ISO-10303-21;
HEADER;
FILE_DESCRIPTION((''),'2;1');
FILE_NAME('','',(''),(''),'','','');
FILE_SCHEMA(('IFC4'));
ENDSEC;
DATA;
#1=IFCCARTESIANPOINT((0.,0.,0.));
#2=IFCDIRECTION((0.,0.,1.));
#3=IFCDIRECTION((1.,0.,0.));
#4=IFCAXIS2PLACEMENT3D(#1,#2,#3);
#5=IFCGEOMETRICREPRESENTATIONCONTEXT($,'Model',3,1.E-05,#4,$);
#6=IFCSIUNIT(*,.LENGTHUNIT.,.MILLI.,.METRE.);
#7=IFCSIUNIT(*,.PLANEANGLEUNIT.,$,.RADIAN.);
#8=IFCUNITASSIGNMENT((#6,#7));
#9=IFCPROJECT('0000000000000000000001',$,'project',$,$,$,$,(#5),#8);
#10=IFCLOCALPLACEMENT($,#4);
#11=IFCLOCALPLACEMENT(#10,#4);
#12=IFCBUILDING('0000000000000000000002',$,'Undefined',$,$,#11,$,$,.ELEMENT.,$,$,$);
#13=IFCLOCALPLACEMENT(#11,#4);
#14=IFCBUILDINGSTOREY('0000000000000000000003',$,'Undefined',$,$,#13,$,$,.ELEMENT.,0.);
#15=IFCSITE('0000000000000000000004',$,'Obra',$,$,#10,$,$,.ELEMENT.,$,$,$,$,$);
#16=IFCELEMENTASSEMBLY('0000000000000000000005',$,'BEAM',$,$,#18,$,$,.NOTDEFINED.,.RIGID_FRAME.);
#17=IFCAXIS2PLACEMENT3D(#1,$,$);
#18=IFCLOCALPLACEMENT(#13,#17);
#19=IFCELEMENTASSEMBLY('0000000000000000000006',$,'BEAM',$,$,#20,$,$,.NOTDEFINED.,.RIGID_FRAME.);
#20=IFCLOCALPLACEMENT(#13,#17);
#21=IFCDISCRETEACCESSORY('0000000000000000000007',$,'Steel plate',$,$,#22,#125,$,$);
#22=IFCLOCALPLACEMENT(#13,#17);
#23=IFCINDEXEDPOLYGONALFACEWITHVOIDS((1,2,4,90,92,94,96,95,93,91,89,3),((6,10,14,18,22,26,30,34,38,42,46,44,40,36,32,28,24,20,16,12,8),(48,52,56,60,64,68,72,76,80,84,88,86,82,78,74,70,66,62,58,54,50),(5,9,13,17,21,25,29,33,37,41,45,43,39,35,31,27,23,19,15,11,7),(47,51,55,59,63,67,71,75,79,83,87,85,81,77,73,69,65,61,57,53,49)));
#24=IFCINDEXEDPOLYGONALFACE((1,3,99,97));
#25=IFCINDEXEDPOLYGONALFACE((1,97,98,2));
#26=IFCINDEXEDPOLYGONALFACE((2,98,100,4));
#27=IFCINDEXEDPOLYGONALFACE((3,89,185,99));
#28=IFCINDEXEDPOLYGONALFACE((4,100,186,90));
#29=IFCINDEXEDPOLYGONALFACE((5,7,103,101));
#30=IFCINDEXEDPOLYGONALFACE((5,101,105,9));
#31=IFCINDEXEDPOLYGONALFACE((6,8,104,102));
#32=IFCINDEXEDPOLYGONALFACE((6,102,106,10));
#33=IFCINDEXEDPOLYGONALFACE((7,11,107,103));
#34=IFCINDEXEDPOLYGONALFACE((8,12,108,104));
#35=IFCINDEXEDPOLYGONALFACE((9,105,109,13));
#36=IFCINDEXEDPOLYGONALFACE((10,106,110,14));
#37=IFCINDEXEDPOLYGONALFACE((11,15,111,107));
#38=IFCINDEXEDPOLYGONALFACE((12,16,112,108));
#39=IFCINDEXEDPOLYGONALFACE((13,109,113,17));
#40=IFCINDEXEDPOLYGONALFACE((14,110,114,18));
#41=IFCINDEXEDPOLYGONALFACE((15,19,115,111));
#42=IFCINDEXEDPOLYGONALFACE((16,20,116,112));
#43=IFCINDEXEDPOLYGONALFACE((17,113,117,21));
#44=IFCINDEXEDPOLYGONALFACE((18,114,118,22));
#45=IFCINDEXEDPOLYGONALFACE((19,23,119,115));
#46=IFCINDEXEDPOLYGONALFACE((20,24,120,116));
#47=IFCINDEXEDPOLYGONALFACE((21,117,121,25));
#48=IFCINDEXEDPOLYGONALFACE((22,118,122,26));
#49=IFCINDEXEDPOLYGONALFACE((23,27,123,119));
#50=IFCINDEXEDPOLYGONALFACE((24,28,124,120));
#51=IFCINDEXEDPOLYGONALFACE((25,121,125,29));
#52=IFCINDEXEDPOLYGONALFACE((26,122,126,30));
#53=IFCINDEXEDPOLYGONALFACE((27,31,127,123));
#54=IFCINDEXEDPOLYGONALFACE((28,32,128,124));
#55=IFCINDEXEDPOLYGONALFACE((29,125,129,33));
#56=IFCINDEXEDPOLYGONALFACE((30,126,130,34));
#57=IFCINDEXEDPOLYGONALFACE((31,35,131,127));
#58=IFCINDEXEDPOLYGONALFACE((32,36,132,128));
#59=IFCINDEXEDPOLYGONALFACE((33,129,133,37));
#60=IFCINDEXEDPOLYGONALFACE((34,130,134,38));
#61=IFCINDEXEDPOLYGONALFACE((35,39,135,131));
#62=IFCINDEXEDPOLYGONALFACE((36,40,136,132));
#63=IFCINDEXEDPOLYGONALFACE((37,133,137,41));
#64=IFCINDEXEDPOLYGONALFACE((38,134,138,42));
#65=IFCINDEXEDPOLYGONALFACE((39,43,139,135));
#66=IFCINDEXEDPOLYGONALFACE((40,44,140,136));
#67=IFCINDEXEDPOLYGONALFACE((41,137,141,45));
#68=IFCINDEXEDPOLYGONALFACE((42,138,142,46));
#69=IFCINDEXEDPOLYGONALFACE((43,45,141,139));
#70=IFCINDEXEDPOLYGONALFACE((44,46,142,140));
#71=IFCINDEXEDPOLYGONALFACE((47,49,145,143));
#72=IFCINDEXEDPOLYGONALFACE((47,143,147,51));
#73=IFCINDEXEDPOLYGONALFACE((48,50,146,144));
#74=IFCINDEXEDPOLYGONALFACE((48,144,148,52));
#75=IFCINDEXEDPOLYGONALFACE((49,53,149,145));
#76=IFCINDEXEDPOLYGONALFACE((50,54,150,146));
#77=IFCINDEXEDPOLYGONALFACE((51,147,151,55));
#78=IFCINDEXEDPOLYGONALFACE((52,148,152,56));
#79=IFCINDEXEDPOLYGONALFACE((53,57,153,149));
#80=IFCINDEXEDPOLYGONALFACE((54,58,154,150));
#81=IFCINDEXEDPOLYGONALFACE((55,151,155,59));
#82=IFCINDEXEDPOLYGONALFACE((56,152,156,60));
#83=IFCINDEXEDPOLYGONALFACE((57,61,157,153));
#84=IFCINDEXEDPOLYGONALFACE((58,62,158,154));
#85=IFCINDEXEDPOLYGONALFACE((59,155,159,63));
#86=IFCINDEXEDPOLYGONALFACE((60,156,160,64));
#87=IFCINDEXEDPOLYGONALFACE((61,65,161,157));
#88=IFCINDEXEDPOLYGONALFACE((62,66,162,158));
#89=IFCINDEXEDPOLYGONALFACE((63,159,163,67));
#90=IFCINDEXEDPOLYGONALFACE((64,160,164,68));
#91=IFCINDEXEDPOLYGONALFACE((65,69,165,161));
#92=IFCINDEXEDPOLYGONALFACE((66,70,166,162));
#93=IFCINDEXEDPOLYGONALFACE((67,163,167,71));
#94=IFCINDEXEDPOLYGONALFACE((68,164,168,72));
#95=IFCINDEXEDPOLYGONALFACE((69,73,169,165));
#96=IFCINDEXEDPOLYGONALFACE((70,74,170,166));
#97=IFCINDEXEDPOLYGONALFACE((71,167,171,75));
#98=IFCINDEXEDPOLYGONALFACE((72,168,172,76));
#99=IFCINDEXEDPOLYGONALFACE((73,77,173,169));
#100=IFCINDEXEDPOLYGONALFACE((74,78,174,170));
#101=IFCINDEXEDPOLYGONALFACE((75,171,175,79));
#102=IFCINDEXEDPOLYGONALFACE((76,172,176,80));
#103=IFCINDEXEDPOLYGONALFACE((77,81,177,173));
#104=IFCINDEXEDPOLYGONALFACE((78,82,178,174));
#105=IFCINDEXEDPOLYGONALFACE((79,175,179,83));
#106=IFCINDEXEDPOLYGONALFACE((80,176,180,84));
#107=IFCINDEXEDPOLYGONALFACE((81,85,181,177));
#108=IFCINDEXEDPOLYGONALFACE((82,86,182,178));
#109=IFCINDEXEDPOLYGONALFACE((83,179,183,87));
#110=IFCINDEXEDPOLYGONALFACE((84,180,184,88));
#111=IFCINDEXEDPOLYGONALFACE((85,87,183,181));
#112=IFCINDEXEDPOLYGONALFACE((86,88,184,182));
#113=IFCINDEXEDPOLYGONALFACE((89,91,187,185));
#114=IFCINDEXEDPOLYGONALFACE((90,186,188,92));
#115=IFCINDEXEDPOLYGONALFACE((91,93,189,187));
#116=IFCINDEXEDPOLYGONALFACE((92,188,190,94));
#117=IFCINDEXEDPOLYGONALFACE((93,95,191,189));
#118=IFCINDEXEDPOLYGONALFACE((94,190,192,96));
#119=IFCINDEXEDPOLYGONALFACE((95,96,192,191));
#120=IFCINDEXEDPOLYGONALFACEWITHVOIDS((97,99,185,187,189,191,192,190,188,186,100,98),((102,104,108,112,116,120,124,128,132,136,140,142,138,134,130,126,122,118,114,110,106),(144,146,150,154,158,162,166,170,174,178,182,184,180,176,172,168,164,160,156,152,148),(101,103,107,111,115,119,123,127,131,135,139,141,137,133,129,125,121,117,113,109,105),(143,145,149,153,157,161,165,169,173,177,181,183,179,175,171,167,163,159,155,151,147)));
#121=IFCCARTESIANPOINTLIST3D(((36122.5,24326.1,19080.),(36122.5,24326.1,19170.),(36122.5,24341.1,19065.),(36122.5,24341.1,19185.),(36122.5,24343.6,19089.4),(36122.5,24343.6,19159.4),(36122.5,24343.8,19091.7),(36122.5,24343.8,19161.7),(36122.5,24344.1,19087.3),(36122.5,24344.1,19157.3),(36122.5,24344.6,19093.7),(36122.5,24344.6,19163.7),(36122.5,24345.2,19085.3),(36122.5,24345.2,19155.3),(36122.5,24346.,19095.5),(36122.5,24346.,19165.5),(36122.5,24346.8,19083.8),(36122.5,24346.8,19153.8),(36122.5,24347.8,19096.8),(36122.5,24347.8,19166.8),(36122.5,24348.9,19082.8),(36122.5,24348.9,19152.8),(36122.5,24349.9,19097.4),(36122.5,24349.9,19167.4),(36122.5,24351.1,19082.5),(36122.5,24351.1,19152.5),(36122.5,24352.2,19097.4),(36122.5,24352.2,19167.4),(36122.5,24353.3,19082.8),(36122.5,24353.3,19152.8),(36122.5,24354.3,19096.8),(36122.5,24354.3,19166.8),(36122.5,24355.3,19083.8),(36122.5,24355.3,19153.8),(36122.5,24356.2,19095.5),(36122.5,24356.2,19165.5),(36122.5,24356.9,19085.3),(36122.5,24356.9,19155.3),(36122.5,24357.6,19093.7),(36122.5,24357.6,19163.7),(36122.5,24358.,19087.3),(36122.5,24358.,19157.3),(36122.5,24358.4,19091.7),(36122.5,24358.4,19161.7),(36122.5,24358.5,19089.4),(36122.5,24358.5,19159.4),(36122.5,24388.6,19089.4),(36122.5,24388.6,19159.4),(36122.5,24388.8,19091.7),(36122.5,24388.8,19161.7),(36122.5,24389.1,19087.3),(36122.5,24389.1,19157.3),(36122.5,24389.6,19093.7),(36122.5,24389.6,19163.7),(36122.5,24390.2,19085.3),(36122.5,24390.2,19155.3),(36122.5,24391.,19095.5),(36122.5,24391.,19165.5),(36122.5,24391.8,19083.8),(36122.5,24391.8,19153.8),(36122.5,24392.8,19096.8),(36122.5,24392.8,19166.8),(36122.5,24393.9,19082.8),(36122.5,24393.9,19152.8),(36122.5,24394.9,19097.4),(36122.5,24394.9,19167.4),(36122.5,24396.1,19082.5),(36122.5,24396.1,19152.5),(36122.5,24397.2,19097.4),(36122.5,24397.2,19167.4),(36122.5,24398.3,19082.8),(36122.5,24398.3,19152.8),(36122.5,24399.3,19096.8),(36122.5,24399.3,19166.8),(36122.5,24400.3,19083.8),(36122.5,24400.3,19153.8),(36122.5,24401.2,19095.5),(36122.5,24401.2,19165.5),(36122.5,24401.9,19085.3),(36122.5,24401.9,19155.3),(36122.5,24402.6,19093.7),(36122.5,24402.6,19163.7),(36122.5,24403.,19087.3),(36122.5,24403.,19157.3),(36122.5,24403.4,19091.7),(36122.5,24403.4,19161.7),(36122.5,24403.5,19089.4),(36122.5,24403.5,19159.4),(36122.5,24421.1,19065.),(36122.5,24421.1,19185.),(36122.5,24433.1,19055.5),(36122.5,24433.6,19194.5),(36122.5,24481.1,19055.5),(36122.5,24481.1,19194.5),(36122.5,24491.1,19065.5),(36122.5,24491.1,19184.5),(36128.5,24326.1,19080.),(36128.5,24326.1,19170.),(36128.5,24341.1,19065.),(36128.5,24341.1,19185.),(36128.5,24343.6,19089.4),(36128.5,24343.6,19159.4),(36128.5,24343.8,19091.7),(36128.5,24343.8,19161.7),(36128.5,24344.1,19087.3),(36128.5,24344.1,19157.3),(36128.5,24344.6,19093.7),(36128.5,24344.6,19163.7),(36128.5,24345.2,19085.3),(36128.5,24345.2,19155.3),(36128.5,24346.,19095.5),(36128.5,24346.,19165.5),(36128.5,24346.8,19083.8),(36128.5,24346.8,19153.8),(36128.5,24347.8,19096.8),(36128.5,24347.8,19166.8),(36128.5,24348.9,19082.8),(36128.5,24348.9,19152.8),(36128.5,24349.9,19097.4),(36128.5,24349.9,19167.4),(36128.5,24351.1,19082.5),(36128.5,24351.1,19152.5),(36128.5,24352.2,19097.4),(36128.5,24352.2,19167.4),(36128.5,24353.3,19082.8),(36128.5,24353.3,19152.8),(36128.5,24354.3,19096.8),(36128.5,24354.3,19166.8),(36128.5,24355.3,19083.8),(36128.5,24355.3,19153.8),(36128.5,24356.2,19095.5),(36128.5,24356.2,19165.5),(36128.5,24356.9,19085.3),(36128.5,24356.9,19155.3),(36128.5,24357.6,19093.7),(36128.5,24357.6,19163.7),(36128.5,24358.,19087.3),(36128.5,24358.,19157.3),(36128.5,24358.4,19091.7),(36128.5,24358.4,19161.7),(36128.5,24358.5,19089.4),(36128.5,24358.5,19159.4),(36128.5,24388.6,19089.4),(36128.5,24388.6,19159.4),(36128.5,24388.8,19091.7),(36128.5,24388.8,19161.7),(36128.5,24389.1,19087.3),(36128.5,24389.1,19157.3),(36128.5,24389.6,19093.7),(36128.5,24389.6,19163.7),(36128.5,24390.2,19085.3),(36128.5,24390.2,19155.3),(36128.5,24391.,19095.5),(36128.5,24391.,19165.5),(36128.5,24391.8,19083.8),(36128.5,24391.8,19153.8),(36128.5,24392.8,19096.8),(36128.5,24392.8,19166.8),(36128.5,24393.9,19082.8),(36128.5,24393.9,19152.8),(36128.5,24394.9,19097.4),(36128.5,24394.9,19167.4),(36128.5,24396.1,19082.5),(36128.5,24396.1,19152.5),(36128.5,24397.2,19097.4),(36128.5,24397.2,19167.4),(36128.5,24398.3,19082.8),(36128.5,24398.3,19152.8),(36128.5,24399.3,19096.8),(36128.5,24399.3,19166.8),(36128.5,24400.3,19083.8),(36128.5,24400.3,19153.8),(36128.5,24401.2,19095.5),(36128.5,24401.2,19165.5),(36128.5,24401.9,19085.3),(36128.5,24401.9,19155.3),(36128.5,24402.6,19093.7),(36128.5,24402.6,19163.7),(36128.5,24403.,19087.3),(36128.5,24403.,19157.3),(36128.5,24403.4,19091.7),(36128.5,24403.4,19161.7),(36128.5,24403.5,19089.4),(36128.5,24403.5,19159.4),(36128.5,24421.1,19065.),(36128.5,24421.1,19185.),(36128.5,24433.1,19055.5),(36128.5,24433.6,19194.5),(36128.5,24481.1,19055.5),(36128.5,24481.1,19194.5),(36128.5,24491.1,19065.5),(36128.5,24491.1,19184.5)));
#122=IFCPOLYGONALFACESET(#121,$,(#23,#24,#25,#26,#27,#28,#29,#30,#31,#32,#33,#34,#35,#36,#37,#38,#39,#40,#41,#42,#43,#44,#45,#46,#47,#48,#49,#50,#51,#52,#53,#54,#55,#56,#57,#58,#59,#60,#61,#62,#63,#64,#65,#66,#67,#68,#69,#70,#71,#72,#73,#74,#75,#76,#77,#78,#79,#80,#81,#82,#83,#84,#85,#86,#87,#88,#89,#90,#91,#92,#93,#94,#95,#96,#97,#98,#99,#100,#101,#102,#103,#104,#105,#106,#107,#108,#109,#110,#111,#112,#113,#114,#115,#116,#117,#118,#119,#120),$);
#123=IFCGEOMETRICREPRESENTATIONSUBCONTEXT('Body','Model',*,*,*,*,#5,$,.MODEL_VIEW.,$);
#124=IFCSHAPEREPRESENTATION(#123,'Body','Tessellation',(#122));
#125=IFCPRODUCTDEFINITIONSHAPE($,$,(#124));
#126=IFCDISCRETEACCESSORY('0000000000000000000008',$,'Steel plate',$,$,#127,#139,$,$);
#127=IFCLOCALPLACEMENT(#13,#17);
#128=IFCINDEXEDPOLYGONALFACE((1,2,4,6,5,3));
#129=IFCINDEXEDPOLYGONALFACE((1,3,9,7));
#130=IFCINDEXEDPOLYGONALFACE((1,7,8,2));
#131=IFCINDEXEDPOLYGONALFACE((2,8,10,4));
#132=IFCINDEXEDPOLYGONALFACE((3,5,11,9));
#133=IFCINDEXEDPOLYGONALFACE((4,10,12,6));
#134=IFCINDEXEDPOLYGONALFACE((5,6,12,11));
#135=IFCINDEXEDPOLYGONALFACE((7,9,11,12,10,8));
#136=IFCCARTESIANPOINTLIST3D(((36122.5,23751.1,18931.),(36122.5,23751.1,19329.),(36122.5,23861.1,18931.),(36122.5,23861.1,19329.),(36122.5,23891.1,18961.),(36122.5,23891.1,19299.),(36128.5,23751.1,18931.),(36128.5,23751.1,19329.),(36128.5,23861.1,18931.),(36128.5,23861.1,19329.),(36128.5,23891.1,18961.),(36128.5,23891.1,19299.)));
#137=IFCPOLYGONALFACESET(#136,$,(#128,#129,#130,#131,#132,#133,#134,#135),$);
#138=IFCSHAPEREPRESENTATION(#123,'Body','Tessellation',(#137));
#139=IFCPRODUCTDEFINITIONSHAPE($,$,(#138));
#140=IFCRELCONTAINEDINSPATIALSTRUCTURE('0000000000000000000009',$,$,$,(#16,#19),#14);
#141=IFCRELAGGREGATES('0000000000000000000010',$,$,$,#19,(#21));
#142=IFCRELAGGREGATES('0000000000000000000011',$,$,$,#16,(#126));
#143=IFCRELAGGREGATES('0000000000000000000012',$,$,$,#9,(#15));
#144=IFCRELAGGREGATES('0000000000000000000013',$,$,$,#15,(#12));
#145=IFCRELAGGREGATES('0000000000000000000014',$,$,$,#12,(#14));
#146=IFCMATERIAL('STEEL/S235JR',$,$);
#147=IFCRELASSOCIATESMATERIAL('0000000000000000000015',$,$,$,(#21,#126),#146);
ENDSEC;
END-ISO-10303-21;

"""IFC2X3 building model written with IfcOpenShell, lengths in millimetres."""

from ifc_helpers import new_model, si_unit, frame, origin_with_axes, origin_2d_with_axis, place, context, subcontext, project, spatial, polyline, circle, outline, extrude, source, transform, mapped, material, element, aggregate, save


model = new_model("IFC2X3")

# Units and contexts
model_context = context("Model", 3, precision=1e-05, world=origin_with_axes())
body_context = subcontext(model_context, "Body", "Model", "MODEL_VIEW")
ifc_project = project(units=[si_unit("LENGTHUNIT", "METRE", prefix="MILLI"), si_unit("PLANEANGLEUNIT", "RADIAN")], contexts=[model_context])

# Site, building, storey
site_placement = place(None, origin_with_axes())
site = spatial("IfcSite", under=ifc_project, at=site_placement, Name="Obra", CompositionType="ELEMENT")
building_placement = place(site_placement, origin_with_axes())
building = spatial("IfcBuilding", under=site, at=building_placement, Name="Undefined", CompositionType="ELEMENT")
storey_placement = place(building_placement, origin_with_axes())
storey = spatial("IfcBuildingStorey", under=building, at=storey_placement, Name="Undefined", CompositionType="ELEMENT", Elevation=0.0)

# Shared definitions
ifc_material_1 = material(Name="STEEL/S235JR")

# Element assembly
assembly_1_placement = place(storey_placement, origin_with_axes())
assembly_1 = element("IfcElementAssembly", 1, at=assembly_1_placement, inside=storey, Name="BEAM", AssemblyPlace="NOTDEFINED", PredefinedType="RIGID_FRAME")

# Element assembly
assembly_2_placement = place(storey_placement, origin_with_axes())
assembly_2 = element("IfcElementAssembly", 2, at=assembly_2_placement, inside=storey, Name="BEAM", AssemblyPlace="NOTDEFINED", PredefinedType="RIGID_FRAME")
shared_shape_1 = source(origin_with_axes(), body_context, "Body", "SweptSolid", [
    extrude(circle(Radius=7.5, at=origin_2d_with_axis()), frame((0.0, 2.4, 0.0), z_axis=(0.0, 1.0, 0.0), x_axis=(1.0, 0.0, 0.0)), (0.0, 0.0, 1.0), 6.2),
])

# Discrete accessory, opening
discrete_accessory_1_placement = place(assembly_2_placement, frame((36125.5, 24491.1, 19065.5), z_axis=(-1.0, 0.0, 0.0), x_axis=(0.000001, -0.707107, -0.707107)))
discrete_accessory_1 = element("IfcDiscreteAccessory", 3, at=discrete_accessory_1_placement, material=ifc_material_1, Name="Steel plate", context=body_context, shape_type="SweptSolid", body=[
    extrude(outline(polyline([(0.0, 0.0), (14.1, 0.0), (48.1, 33.9), (49.9, 49.1), (106.4, 105.7), (106.4, 126.9), (42.8, 190.6), (21.6, 190.6), (-35.0, 134.0), (-50.6, 131.9), (-84.1, 98.3), (-84.1, 84.1), (0.0, 0.0)])), frame((0.0, 0.0, -3.0), z_axis=(0.0, 0.0, 1.0), x_axis=(1.0, 0.0, 0.0)), (0.0, 0.0, 1.0), 6.0),
])
opening_1_placement = place(assembly_2_placement, frame((36120.0, 24373.6, 19160.0), z_axis=(0.0, -1.0, 0.0), x_axis=(0.0, 0.0, -1.0)))
element("IfcOpeningElement", 4, at=opening_1_placement, cuts=discrete_accessory_1, ObjectType="Opening", context=body_context, shape_type="MappedRepresentation", body=[
    mapped(shared_shape_1, transform((0.0, 0.0, -22.5))),
    mapped(shared_shape_1, transform((70.0, 0.0, -22.5))),
    mapped(shared_shape_1, transform((0.0, 0.0, 22.5))),
    mapped(shared_shape_1, transform((70.0, 0.0, 22.5))),
])
aggregate(assembly_2, [discrete_accessory_1])

# Discrete accessory
discrete_accessory_2_placement = place(assembly_1_placement, frame((36125.5, 23891.1, 18931.0), z_axis=(-1.0, 0.0, 0.0), x_axis=(0.0, -1.0, 0.0)))
discrete_accessory_2 = element("IfcDiscreteAccessory", 5, at=discrete_accessory_2_placement, material=ifc_material_1, Name="Steel plate", context=body_context, shape_type="SweptSolid", body=[
    extrude(outline(polyline([(0.0, 30.0), (30.0, 0.0), (140.0, 0.0), (140.0, 398.0), (30.0, 398.0), (0.0, 368.0), (0.0, 30.0)])), frame((0.0, 0.0, -3.0), z_axis=(0.0, 0.0, 1.0), x_axis=(1.0, 0.0, 0.0)), (0.0, 0.0, 1.0), 6.0),
])

aggregate(assembly_1, [discrete_accessory_2])

save(model, "model.ifc")
